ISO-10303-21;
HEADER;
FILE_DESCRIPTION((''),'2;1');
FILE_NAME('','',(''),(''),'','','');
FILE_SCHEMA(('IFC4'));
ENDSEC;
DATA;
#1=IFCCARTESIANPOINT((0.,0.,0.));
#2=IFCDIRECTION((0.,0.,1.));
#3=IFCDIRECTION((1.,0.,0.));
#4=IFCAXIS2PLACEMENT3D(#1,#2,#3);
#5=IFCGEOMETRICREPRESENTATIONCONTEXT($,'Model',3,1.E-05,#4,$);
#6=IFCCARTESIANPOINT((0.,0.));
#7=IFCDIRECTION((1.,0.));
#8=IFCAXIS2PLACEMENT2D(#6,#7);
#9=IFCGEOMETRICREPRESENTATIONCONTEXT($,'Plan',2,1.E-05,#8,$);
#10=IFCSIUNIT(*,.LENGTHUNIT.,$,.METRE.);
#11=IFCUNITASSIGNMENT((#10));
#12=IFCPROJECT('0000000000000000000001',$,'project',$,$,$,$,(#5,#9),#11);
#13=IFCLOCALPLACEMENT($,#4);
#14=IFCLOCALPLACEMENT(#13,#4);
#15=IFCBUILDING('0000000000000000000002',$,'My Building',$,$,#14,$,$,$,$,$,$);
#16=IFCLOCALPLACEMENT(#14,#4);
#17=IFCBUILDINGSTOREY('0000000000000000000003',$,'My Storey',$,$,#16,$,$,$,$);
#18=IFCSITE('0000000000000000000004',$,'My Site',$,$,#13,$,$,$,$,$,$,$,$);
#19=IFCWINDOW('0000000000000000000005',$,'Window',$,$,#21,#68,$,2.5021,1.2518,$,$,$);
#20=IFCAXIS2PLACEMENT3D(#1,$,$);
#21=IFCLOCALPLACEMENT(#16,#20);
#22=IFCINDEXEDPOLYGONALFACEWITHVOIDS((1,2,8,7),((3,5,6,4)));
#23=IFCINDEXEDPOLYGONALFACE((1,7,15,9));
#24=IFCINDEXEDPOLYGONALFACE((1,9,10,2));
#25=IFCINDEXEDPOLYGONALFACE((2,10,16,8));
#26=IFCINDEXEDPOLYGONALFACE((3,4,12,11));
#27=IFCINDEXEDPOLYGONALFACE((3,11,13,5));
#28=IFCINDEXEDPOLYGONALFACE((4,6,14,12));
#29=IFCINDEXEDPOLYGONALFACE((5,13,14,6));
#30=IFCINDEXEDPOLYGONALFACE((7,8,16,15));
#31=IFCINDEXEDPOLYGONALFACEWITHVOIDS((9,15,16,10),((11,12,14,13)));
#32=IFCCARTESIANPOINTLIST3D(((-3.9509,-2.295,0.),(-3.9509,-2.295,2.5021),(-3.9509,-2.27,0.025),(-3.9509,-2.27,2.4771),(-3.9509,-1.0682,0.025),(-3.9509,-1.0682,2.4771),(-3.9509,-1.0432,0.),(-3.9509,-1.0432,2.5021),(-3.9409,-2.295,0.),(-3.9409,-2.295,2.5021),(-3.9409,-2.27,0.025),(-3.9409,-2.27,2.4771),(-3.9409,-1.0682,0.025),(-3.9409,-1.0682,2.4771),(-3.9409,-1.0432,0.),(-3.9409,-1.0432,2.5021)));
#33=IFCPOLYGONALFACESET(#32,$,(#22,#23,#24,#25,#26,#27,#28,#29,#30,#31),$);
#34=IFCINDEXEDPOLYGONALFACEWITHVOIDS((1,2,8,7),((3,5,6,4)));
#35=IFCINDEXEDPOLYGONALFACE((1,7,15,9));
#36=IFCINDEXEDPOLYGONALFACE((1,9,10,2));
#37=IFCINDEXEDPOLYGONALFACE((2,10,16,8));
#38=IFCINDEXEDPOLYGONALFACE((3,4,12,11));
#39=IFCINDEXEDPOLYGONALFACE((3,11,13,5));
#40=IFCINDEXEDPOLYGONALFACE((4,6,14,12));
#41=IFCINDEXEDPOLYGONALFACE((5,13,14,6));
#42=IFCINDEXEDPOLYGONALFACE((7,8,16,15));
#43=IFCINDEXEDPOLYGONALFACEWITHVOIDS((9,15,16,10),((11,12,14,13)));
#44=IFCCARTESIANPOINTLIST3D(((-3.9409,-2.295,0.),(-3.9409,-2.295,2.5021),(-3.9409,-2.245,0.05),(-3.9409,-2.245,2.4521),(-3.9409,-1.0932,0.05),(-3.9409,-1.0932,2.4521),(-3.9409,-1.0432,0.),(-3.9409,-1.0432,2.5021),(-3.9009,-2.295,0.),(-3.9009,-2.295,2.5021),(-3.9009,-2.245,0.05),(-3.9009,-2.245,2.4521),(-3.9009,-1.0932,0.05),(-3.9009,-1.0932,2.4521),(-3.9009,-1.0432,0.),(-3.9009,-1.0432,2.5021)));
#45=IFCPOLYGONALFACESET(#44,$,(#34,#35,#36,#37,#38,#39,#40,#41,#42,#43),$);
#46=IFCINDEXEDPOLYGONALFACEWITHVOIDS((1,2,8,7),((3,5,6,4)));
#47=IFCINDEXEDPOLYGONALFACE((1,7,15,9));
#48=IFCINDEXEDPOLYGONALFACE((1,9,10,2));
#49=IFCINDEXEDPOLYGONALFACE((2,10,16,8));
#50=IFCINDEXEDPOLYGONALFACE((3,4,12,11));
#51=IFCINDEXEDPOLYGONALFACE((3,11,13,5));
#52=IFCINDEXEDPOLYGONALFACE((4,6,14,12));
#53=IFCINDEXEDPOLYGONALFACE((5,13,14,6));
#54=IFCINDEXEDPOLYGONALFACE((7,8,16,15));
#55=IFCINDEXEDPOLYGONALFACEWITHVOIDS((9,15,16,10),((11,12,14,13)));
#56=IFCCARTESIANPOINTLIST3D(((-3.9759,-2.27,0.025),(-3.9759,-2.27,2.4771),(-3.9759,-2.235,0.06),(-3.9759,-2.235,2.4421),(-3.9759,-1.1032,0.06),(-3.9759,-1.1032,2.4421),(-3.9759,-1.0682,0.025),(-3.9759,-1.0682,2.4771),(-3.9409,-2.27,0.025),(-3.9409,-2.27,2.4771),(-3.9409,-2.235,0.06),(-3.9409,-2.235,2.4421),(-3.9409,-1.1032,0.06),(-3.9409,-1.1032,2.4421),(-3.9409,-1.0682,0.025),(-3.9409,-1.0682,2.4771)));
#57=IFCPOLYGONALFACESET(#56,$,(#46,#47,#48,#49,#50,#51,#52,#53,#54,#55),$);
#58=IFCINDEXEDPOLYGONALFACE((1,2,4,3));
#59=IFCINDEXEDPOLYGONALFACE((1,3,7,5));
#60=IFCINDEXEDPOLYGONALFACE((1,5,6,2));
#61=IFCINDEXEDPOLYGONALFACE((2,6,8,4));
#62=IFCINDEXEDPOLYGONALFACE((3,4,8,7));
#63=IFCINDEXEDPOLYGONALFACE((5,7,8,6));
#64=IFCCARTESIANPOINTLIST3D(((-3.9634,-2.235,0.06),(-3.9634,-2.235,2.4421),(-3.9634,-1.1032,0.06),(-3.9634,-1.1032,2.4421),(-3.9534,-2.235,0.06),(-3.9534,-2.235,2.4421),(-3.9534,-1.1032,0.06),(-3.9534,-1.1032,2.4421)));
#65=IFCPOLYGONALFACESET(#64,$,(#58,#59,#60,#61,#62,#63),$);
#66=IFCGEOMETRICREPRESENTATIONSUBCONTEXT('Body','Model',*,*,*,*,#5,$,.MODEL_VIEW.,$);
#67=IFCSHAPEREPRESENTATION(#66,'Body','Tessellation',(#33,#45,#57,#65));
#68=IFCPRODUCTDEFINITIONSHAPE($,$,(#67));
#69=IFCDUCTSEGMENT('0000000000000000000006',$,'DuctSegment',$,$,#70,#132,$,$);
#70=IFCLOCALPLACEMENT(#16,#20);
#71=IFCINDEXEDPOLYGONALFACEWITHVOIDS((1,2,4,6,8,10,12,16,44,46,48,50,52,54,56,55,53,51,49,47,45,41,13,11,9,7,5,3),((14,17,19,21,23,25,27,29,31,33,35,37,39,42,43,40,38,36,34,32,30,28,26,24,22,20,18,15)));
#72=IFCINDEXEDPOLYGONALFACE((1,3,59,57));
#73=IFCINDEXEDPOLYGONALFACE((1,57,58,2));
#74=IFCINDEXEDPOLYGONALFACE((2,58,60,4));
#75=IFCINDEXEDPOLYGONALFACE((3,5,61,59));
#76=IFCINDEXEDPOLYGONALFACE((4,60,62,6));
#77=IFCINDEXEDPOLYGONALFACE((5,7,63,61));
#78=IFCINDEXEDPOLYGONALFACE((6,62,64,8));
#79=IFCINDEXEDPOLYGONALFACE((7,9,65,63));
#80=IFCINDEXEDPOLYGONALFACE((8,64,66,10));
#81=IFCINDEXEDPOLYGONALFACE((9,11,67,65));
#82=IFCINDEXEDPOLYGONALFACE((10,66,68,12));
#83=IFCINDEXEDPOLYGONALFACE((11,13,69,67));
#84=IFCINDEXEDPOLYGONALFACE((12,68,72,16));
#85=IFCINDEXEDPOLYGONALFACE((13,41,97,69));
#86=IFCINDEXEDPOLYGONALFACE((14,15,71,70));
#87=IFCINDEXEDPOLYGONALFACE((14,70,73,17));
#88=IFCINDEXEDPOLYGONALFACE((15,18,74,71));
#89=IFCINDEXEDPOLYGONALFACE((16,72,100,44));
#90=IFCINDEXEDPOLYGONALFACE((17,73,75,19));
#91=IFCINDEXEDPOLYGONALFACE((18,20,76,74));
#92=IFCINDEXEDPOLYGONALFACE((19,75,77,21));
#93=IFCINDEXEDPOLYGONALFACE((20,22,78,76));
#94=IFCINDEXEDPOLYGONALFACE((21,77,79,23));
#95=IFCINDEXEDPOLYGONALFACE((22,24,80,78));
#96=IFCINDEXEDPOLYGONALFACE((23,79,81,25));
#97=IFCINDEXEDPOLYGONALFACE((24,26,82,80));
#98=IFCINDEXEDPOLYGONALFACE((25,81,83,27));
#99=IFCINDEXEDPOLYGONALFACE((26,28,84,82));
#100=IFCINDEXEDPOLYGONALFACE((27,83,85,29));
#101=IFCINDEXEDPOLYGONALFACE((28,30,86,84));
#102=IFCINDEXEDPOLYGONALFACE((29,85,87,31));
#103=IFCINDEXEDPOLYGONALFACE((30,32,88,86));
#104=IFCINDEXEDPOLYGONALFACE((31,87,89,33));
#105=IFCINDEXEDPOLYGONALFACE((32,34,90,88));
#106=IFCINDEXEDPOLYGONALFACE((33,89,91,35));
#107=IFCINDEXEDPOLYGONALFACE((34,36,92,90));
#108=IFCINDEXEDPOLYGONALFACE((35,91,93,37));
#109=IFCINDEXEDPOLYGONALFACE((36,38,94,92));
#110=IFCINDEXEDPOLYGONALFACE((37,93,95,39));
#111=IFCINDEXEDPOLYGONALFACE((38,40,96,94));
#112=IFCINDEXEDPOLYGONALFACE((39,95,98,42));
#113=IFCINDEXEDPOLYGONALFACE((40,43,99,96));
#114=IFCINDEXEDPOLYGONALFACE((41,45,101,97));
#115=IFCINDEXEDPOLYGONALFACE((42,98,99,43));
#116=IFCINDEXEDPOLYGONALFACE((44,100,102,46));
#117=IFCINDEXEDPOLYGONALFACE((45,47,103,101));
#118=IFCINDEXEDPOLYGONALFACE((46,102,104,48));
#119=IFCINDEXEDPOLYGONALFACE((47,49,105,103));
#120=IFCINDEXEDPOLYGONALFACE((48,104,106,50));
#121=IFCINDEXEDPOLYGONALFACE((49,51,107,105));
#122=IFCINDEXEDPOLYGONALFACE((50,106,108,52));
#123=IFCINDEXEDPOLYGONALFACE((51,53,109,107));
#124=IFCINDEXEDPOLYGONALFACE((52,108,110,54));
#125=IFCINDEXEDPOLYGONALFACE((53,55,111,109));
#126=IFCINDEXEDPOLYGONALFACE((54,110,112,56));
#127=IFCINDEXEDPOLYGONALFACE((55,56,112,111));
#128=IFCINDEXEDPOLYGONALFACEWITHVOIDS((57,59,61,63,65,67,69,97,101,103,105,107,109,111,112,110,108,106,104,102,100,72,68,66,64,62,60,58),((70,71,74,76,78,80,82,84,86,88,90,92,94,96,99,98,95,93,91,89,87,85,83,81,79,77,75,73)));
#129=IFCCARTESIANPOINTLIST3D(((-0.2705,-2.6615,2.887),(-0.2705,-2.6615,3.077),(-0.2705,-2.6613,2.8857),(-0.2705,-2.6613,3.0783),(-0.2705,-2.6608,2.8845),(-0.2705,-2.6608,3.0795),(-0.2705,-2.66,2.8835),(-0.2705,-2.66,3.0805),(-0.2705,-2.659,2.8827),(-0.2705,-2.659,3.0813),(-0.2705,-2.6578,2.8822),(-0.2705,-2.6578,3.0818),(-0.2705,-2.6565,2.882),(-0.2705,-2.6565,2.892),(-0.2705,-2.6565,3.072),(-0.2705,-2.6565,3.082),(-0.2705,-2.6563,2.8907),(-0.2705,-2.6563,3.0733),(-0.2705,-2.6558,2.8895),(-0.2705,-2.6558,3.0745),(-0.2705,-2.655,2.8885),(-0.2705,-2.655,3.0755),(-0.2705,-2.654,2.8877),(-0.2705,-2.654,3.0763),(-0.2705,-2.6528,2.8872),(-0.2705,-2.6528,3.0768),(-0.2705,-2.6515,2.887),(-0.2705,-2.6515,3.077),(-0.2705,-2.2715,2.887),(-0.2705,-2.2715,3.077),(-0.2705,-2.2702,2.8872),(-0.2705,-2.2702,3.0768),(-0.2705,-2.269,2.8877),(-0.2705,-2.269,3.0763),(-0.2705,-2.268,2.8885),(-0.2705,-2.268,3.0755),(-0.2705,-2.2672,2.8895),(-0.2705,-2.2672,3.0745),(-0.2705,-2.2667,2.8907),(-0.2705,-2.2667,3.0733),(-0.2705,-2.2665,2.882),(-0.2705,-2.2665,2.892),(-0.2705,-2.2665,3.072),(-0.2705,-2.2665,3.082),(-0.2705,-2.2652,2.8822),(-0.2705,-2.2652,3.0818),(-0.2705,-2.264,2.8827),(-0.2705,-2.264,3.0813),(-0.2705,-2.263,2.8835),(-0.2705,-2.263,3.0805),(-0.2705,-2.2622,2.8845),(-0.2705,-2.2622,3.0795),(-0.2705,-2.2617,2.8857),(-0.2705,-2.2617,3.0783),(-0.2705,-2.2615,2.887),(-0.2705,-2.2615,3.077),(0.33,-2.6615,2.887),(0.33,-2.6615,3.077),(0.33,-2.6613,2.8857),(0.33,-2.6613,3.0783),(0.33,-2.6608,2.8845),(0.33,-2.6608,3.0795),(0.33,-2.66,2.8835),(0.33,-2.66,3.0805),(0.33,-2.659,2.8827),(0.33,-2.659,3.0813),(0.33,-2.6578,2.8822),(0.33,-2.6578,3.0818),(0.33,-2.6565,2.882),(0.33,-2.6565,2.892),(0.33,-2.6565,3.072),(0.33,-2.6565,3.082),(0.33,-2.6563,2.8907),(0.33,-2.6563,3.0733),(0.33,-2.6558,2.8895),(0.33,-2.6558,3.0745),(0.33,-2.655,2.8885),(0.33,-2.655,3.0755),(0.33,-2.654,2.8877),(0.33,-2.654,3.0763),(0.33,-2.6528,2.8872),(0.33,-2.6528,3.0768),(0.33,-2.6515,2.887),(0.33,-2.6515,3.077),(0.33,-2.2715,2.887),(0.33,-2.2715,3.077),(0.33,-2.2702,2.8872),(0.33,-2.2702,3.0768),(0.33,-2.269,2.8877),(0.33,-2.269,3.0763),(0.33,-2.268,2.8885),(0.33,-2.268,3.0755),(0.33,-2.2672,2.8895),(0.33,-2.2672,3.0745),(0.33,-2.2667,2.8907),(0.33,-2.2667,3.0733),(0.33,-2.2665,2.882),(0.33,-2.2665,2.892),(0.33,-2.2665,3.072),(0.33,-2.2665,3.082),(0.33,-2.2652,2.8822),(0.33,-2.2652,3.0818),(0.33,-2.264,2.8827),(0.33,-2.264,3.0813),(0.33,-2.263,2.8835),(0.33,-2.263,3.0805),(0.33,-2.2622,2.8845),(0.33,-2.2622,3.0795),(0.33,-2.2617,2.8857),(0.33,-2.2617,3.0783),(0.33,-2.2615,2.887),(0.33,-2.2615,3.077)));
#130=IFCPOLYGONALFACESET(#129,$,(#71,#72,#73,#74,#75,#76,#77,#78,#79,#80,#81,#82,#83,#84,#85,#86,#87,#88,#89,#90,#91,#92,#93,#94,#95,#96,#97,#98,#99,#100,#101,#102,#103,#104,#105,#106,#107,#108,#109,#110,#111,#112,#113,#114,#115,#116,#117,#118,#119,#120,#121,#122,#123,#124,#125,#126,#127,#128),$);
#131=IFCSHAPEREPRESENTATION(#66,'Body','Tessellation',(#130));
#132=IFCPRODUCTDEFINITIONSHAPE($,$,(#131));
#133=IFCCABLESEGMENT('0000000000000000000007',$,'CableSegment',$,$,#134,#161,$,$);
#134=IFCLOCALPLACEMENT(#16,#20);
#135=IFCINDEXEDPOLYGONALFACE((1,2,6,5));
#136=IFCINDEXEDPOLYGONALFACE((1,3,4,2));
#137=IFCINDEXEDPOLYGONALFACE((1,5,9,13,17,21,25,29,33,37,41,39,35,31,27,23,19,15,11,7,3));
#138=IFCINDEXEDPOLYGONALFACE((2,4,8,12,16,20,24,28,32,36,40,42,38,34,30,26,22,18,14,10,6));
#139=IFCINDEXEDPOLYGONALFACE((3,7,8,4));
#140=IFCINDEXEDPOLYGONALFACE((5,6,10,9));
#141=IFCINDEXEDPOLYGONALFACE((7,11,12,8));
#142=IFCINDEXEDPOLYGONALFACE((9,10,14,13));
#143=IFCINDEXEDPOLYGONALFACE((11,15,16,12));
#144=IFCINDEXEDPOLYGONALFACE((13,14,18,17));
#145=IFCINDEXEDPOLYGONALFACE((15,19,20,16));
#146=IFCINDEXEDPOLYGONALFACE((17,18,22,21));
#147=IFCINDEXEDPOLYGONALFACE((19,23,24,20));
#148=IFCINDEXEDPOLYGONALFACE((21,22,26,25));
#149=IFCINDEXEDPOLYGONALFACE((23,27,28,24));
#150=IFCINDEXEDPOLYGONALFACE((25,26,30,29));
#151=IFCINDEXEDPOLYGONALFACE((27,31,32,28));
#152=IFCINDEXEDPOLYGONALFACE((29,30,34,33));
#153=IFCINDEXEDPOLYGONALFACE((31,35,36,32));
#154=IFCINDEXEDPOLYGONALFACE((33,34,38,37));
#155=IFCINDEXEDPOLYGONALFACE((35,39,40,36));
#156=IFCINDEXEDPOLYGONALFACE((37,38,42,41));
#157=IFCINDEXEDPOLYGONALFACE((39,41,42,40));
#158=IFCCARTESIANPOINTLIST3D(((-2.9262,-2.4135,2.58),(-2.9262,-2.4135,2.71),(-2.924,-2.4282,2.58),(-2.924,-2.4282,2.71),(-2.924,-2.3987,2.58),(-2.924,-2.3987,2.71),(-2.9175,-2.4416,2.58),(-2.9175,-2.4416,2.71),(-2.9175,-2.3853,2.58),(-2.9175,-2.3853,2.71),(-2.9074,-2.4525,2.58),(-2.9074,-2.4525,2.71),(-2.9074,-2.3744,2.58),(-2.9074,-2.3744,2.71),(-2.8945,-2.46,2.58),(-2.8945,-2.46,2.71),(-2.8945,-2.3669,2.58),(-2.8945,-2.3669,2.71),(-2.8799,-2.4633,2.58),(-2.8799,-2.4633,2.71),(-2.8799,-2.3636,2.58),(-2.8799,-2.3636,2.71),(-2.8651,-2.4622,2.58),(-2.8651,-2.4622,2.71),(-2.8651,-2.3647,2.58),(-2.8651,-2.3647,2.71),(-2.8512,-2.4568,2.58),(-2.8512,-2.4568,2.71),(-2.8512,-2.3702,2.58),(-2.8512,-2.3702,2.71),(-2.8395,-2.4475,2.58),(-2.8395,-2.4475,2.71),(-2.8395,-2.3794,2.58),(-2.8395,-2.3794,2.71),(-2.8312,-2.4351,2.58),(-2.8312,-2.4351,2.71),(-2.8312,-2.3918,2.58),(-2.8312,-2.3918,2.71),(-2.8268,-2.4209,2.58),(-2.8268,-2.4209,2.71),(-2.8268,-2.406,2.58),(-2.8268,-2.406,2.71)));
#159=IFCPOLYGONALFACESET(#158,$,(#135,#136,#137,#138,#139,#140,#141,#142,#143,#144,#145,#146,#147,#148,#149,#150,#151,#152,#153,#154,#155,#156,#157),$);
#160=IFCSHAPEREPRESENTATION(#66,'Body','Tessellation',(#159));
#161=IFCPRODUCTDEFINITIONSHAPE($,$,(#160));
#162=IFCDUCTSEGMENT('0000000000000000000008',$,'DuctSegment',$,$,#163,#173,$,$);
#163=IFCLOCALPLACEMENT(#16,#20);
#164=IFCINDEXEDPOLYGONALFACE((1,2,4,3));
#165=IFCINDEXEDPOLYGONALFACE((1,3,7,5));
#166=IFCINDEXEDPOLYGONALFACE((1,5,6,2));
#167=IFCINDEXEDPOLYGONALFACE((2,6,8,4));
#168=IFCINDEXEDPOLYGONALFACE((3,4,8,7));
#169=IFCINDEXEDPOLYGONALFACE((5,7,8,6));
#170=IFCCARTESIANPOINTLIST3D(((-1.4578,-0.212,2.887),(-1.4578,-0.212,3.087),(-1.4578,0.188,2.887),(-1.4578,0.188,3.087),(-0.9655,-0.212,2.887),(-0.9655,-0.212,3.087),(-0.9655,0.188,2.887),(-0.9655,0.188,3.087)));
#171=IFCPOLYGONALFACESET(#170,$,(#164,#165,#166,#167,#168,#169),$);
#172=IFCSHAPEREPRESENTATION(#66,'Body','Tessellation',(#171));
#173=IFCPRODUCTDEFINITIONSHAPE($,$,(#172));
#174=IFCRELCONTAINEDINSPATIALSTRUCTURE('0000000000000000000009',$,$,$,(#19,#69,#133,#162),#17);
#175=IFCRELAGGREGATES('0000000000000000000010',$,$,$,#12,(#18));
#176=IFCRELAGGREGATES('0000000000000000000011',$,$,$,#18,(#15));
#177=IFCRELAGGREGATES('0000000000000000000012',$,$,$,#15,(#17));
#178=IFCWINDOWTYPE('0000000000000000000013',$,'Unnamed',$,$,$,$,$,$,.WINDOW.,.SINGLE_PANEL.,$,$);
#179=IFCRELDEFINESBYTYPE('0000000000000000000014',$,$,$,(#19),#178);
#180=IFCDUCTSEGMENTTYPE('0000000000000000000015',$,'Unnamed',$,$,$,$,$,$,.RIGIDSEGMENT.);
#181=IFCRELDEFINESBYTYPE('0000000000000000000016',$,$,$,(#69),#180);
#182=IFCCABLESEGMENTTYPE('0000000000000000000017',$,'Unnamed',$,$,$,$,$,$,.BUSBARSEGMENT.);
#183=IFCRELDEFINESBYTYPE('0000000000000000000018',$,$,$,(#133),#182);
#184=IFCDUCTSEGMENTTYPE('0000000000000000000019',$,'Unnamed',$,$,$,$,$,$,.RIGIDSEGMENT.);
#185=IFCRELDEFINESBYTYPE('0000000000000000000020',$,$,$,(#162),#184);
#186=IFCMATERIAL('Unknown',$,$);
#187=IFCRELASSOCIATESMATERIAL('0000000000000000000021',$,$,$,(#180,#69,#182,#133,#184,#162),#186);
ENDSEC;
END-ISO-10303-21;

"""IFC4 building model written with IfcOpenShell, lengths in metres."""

from ifc_helpers import new_model, entity, si_unit, frame, origin_with_axes, origin_2d_with_axis, place, context, subcontext, project, spatial, line, indexed_curve, rectangle, hollow_rectangle, circle, outline, extrude, shape, source, transform, mapped, material, material_profile, profile_set, profile_usage, type_object, type_shapes, element, save


model = new_model("IFC4")

# Units and contexts
model_context = context("Model", 3, precision=1e-05, world=origin_with_axes())
plan_context = context("Plan", 2, precision=1e-05, world=origin_2d_with_axis())
body_context_1 = subcontext(model_context, "Body", "Model", "MODEL_VIEW")
body_context_2 = subcontext(plan_context, "Body", "Plan", "PLAN_VIEW")
ifc_project = project(units=[si_unit("LENGTHUNIT", "METRE")], contexts=[model_context, plan_context])

# Site, building, storey
site_placement = place(None, origin_with_axes())
site = spatial("IfcSite", under=ifc_project, at=site_placement, Name="My Site")
building_placement = place(site_placement, origin_with_axes())
building = spatial("IfcBuilding", under=site, at=building_placement, Name="My Building")
storey_placement = place(building_placement, origin_with_axes())
storey = spatial("IfcBuildingStorey", under=building, at=storey_placement, Name="My Storey")

# Shared definitions
ifc_material = material(Name="Unknown")

# Window
window_type = type_object("IfcWindowType", Name="Unnamed", PartitioningType="SINGLE_PANEL", PredefinedType="WINDOW")
shared_shape_1 = source(origin_with_axes(), body_context_1, "Body", "SweptSolid", [
    extrude(outline(indexed_curve([(0.0, 0.0), (1.2518, 0.0), (1.2518, 2.5021), (0.0, 2.5021)], segments=[line(1, 2, 3, 4, 1)]), holes=[indexed_curve([(0.025, 0.025), (1.2268, 0.025), (1.2268, 2.4771), (0.025, 2.4771)], segments=[line(1, 2, 3, 4, 1)])]), frame((0.0, 0.09, 0.0), z_axis=(0.0, -1.0, 0.0), x_axis=(1.0, 0.0, 0.0)), (0.0, 0.0, -1.0), 0.01),
    extrude(outline(indexed_curve([(0.0, 0.0), (1.2518, 0.0), (1.2518, 2.5021), (0.0, 2.5021)], segments=[line(1, 2, 3, 4, 1)]), holes=[indexed_curve([(0.05, 0.05), (1.2018, 0.05), (1.2018, 2.4521), (0.05, 2.4521)], segments=[line(1, 2, 3, 4, 1)])]), frame((0.0, 0.05, 0.0), z_axis=(0.0, -1.0, 0.0), x_axis=(1.0, 0.0, 0.0)), (0.0, 0.0, -1.0), 0.04),
    extrude(outline(indexed_curve([(0.0, 0.0), (1.2018, 0.0), (1.2018, 2.4521), (0.0, 2.4521)], segments=[line(1, 2, 3, 4, 1)]), holes=[indexed_curve([(0.035, 0.035), (1.1668, 0.035), (1.1668, 2.4171), (0.035, 2.4171)], segments=[line(1, 2, 3, 4, 1)])]), frame((0.025, 0.09, 0.025), z_axis=(0.0, -1.0, 0.0), x_axis=(1.0, 0.0, 0.0)), (0.0, 0.0, -1.0), 0.035),
    extrude(outline(indexed_curve([(0.035, 0.035), (1.1668, 0.035), (1.1668, 2.4171), (0.035, 2.4171)], segments=[line(1, 2, 3, 4, 1)])), frame((0.025, 0.1025, 0.025), z_axis=(0.0, -1.0, 0.0), x_axis=(1.0, 0.0, 0.0)), (0.0, 0.0, -1.0), 0.01),
])
shared_shape_2 = source(origin_with_axes(), body_context_2, "Body", "Curve2D", [
    entity("IfcIndexedPolyCurve", entity("IfcCartesianPointList2D", [[0.05, 0.05], [1.2018, 0.05]])),
    entity("IfcIndexedPolyCurve", entity("IfcCartesianPointList2D", [[0.0, 0.1], [0.025, 0.1], [0.025, 0.09], [0.05, 0.09], [0.05, 0.05], [0.0, 0.05]]), [entity("IfcLineIndex", [1, 2, 3, 4, 5, 6, 1])]),
    entity("IfcIndexedPolyCurve", entity("IfcCartesianPointList2D", [[1.2518, 0.1], [1.2268, 0.1], [1.2268, 0.09], [1.2018, 0.09], [1.2018, 0.05], [1.2518, 0.05]]), [entity("IfcLineIndex", [1, 2, 3, 4, 5, 6, 1])]),
    entity("IfcIndexedPolyCurve", entity("IfcCartesianPointList2D", [[0.025, 0.09], [0.06, 0.09], [0.06, 0.125], [0.025, 0.125]]), [entity("IfcLineIndex", [1, 2, 3, 4, 1])]),
    entity("IfcIndexedPolyCurve", entity("IfcCartesianPointList2D", [[1.2268, 0.09], [1.1918, 0.09], [1.1918, 0.125], [1.2268, 0.125]]), [entity("IfcLineIndex", [1, 2, 3, 4, 1])]),
    entity("IfcIndexedPolyCurve", entity("IfcCartesianPointList2D", [[0.06, 0.09], [1.1918, 0.09]])),
    entity("IfcIndexedPolyCurve", entity("IfcCartesianPointList2D", [[0.06, 0.125], [1.1918, 0.125]])),
    entity("IfcIndexedPolyCurve", entity("IfcCartesianPointList2D", [[0.06, 0.1075], [1.1918, 0.1075]])),
])
type_shapes(window_type, [shared_shape_1, shared_shape_2])
for number, where, z_axis, x_axis, name in (
    (1, (-3.8509, -2.295, 0.0), (0.0, 0.0, 1.0), (0.0, 1.0, 0.0), "Window"),
):
    element("IfcWindow", number, at=place(storey_placement, frame(where, z_axis=z_axis, x_axis=x_axis)), inside=storey, type_object=window_type, Name=name, OverallHeight=2.5021, OverallWidth=1.2518, shapes=[
        shape(body_context_1, "Body", "MappedRepresentation", [mapped(shared_shape_1, transform((0.0, 0.0, 0.0), x_axis=(1.0, 0.0, 0.0), y_axis=(0.0, 1.0, 0.0), z_axis=(0.0, 0.0, 1.0), scale=1.0))]),
        shape(body_context_2, "Body", "MappedRepresentation", [mapped(shared_shape_2, transform((0.0, 0.0, 0.0), x_axis=(1.0, 0.0, 0.0), y_axis=(0.0, 1.0, 0.0), z_axis=(0.0, 0.0, 1.0), scale=1.0))]),
    ])

# Duct segment
ifc_material_profile_1 = material_profile(ifc_material, hollow_rectangle(XDim=0.4, YDim=0.2, WallThickness=0.005, InnerFilletRadius=0.005, OuterFilletRadius=0.005))
ifc_profile_set_1 = profile_set([ifc_material_profile_1])
ifc_profile_usage_1 = profile_usage(ifc_profile_set_1, cardinal=5)
duct_segment_type_1 = type_object("IfcDuctSegmentType", Name="Unnamed", PredefinedType="RIGIDSEGMENT", material=ifc_profile_set_1)
duct_segment_1_placement = place(storey_placement, frame((-0.2705, -2.4615, 2.982), z_axis=(1.0, 0.0, 0.0), x_axis=(0.0, 1.0, 0.0)))
element("IfcDuctSegment", 2, at=duct_segment_1_placement, inside=storey, type_object=duct_segment_type_1, material=ifc_profile_usage_1, Name="DuctSegment", context=body_context_1, shape_type="SweptSolid", body=[
    extrude(hollow_rectangle(XDim=0.4, YDim=0.2, WallThickness=0.005, InnerFilletRadius=0.005, OuterFilletRadius=0.005), origin_with_axes(), (0.0, 0.0, 1.0), 0.6005),
])

# Cable segment
ifc_material_profile_2 = material_profile(ifc_material, circle(Radius=0.05))
ifc_profile_set_2 = profile_set([ifc_material_profile_2])
ifc_profile_usage_2 = profile_usage(ifc_profile_set_2, cardinal=5)
cable_segment_type = type_object("IfcCableSegmentType", Name="Unnamed", PredefinedType="BUSBARSEGMENT", material=ifc_profile_set_2)
cable_segment_placement = place(storey_placement, frame((-2.8762, -2.4135, 2.71), z_axis=(0.0, 0.0, -1.0), x_axis=(-1.0, 0.0, 0.0)))
element("IfcCableSegment", 3, at=cable_segment_placement, inside=storey, type_object=cable_segment_type, material=ifc_profile_usage_2, Name="CableSegment", context=body_context_1, shape_type="SweptSolid", body=[
    extrude(circle(Radius=0.05), origin_with_axes(), (0.0, 0.0, 1.0), 0.13),
])

# Duct segment
ifc_material_profile_3 = material_profile(ifc_material, rectangle(XDim=0.4, YDim=0.2))
ifc_profile_set_3 = profile_set([ifc_material_profile_3])
ifc_profile_usage_3 = profile_usage(ifc_profile_set_3, cardinal=5)
duct_segment_type_2 = type_object("IfcDuctSegmentType", Name="Unnamed", PredefinedType="RIGIDSEGMENT", material=ifc_profile_set_3)
duct_segment_2_placement = place(storey_placement, frame((-0.9655, -0.012, 2.987), z_axis=(-1.0, 0.0, 0.0), x_axis=(0.0, -1.0, 0.0)))
element("IfcDuctSegment", 4, at=duct_segment_2_placement, inside=storey, type_object=duct_segment_type_2, material=ifc_profile_usage_3, Name="DuctSegment", context=body_context_1, shape_type="SweptSolid", body=[
    extrude(rectangle(XDim=0.4, YDim=0.2), origin_with_axes(), (0.0, 0.0, 1.0), 0.4923),
])

save(model, "model.ifc")
